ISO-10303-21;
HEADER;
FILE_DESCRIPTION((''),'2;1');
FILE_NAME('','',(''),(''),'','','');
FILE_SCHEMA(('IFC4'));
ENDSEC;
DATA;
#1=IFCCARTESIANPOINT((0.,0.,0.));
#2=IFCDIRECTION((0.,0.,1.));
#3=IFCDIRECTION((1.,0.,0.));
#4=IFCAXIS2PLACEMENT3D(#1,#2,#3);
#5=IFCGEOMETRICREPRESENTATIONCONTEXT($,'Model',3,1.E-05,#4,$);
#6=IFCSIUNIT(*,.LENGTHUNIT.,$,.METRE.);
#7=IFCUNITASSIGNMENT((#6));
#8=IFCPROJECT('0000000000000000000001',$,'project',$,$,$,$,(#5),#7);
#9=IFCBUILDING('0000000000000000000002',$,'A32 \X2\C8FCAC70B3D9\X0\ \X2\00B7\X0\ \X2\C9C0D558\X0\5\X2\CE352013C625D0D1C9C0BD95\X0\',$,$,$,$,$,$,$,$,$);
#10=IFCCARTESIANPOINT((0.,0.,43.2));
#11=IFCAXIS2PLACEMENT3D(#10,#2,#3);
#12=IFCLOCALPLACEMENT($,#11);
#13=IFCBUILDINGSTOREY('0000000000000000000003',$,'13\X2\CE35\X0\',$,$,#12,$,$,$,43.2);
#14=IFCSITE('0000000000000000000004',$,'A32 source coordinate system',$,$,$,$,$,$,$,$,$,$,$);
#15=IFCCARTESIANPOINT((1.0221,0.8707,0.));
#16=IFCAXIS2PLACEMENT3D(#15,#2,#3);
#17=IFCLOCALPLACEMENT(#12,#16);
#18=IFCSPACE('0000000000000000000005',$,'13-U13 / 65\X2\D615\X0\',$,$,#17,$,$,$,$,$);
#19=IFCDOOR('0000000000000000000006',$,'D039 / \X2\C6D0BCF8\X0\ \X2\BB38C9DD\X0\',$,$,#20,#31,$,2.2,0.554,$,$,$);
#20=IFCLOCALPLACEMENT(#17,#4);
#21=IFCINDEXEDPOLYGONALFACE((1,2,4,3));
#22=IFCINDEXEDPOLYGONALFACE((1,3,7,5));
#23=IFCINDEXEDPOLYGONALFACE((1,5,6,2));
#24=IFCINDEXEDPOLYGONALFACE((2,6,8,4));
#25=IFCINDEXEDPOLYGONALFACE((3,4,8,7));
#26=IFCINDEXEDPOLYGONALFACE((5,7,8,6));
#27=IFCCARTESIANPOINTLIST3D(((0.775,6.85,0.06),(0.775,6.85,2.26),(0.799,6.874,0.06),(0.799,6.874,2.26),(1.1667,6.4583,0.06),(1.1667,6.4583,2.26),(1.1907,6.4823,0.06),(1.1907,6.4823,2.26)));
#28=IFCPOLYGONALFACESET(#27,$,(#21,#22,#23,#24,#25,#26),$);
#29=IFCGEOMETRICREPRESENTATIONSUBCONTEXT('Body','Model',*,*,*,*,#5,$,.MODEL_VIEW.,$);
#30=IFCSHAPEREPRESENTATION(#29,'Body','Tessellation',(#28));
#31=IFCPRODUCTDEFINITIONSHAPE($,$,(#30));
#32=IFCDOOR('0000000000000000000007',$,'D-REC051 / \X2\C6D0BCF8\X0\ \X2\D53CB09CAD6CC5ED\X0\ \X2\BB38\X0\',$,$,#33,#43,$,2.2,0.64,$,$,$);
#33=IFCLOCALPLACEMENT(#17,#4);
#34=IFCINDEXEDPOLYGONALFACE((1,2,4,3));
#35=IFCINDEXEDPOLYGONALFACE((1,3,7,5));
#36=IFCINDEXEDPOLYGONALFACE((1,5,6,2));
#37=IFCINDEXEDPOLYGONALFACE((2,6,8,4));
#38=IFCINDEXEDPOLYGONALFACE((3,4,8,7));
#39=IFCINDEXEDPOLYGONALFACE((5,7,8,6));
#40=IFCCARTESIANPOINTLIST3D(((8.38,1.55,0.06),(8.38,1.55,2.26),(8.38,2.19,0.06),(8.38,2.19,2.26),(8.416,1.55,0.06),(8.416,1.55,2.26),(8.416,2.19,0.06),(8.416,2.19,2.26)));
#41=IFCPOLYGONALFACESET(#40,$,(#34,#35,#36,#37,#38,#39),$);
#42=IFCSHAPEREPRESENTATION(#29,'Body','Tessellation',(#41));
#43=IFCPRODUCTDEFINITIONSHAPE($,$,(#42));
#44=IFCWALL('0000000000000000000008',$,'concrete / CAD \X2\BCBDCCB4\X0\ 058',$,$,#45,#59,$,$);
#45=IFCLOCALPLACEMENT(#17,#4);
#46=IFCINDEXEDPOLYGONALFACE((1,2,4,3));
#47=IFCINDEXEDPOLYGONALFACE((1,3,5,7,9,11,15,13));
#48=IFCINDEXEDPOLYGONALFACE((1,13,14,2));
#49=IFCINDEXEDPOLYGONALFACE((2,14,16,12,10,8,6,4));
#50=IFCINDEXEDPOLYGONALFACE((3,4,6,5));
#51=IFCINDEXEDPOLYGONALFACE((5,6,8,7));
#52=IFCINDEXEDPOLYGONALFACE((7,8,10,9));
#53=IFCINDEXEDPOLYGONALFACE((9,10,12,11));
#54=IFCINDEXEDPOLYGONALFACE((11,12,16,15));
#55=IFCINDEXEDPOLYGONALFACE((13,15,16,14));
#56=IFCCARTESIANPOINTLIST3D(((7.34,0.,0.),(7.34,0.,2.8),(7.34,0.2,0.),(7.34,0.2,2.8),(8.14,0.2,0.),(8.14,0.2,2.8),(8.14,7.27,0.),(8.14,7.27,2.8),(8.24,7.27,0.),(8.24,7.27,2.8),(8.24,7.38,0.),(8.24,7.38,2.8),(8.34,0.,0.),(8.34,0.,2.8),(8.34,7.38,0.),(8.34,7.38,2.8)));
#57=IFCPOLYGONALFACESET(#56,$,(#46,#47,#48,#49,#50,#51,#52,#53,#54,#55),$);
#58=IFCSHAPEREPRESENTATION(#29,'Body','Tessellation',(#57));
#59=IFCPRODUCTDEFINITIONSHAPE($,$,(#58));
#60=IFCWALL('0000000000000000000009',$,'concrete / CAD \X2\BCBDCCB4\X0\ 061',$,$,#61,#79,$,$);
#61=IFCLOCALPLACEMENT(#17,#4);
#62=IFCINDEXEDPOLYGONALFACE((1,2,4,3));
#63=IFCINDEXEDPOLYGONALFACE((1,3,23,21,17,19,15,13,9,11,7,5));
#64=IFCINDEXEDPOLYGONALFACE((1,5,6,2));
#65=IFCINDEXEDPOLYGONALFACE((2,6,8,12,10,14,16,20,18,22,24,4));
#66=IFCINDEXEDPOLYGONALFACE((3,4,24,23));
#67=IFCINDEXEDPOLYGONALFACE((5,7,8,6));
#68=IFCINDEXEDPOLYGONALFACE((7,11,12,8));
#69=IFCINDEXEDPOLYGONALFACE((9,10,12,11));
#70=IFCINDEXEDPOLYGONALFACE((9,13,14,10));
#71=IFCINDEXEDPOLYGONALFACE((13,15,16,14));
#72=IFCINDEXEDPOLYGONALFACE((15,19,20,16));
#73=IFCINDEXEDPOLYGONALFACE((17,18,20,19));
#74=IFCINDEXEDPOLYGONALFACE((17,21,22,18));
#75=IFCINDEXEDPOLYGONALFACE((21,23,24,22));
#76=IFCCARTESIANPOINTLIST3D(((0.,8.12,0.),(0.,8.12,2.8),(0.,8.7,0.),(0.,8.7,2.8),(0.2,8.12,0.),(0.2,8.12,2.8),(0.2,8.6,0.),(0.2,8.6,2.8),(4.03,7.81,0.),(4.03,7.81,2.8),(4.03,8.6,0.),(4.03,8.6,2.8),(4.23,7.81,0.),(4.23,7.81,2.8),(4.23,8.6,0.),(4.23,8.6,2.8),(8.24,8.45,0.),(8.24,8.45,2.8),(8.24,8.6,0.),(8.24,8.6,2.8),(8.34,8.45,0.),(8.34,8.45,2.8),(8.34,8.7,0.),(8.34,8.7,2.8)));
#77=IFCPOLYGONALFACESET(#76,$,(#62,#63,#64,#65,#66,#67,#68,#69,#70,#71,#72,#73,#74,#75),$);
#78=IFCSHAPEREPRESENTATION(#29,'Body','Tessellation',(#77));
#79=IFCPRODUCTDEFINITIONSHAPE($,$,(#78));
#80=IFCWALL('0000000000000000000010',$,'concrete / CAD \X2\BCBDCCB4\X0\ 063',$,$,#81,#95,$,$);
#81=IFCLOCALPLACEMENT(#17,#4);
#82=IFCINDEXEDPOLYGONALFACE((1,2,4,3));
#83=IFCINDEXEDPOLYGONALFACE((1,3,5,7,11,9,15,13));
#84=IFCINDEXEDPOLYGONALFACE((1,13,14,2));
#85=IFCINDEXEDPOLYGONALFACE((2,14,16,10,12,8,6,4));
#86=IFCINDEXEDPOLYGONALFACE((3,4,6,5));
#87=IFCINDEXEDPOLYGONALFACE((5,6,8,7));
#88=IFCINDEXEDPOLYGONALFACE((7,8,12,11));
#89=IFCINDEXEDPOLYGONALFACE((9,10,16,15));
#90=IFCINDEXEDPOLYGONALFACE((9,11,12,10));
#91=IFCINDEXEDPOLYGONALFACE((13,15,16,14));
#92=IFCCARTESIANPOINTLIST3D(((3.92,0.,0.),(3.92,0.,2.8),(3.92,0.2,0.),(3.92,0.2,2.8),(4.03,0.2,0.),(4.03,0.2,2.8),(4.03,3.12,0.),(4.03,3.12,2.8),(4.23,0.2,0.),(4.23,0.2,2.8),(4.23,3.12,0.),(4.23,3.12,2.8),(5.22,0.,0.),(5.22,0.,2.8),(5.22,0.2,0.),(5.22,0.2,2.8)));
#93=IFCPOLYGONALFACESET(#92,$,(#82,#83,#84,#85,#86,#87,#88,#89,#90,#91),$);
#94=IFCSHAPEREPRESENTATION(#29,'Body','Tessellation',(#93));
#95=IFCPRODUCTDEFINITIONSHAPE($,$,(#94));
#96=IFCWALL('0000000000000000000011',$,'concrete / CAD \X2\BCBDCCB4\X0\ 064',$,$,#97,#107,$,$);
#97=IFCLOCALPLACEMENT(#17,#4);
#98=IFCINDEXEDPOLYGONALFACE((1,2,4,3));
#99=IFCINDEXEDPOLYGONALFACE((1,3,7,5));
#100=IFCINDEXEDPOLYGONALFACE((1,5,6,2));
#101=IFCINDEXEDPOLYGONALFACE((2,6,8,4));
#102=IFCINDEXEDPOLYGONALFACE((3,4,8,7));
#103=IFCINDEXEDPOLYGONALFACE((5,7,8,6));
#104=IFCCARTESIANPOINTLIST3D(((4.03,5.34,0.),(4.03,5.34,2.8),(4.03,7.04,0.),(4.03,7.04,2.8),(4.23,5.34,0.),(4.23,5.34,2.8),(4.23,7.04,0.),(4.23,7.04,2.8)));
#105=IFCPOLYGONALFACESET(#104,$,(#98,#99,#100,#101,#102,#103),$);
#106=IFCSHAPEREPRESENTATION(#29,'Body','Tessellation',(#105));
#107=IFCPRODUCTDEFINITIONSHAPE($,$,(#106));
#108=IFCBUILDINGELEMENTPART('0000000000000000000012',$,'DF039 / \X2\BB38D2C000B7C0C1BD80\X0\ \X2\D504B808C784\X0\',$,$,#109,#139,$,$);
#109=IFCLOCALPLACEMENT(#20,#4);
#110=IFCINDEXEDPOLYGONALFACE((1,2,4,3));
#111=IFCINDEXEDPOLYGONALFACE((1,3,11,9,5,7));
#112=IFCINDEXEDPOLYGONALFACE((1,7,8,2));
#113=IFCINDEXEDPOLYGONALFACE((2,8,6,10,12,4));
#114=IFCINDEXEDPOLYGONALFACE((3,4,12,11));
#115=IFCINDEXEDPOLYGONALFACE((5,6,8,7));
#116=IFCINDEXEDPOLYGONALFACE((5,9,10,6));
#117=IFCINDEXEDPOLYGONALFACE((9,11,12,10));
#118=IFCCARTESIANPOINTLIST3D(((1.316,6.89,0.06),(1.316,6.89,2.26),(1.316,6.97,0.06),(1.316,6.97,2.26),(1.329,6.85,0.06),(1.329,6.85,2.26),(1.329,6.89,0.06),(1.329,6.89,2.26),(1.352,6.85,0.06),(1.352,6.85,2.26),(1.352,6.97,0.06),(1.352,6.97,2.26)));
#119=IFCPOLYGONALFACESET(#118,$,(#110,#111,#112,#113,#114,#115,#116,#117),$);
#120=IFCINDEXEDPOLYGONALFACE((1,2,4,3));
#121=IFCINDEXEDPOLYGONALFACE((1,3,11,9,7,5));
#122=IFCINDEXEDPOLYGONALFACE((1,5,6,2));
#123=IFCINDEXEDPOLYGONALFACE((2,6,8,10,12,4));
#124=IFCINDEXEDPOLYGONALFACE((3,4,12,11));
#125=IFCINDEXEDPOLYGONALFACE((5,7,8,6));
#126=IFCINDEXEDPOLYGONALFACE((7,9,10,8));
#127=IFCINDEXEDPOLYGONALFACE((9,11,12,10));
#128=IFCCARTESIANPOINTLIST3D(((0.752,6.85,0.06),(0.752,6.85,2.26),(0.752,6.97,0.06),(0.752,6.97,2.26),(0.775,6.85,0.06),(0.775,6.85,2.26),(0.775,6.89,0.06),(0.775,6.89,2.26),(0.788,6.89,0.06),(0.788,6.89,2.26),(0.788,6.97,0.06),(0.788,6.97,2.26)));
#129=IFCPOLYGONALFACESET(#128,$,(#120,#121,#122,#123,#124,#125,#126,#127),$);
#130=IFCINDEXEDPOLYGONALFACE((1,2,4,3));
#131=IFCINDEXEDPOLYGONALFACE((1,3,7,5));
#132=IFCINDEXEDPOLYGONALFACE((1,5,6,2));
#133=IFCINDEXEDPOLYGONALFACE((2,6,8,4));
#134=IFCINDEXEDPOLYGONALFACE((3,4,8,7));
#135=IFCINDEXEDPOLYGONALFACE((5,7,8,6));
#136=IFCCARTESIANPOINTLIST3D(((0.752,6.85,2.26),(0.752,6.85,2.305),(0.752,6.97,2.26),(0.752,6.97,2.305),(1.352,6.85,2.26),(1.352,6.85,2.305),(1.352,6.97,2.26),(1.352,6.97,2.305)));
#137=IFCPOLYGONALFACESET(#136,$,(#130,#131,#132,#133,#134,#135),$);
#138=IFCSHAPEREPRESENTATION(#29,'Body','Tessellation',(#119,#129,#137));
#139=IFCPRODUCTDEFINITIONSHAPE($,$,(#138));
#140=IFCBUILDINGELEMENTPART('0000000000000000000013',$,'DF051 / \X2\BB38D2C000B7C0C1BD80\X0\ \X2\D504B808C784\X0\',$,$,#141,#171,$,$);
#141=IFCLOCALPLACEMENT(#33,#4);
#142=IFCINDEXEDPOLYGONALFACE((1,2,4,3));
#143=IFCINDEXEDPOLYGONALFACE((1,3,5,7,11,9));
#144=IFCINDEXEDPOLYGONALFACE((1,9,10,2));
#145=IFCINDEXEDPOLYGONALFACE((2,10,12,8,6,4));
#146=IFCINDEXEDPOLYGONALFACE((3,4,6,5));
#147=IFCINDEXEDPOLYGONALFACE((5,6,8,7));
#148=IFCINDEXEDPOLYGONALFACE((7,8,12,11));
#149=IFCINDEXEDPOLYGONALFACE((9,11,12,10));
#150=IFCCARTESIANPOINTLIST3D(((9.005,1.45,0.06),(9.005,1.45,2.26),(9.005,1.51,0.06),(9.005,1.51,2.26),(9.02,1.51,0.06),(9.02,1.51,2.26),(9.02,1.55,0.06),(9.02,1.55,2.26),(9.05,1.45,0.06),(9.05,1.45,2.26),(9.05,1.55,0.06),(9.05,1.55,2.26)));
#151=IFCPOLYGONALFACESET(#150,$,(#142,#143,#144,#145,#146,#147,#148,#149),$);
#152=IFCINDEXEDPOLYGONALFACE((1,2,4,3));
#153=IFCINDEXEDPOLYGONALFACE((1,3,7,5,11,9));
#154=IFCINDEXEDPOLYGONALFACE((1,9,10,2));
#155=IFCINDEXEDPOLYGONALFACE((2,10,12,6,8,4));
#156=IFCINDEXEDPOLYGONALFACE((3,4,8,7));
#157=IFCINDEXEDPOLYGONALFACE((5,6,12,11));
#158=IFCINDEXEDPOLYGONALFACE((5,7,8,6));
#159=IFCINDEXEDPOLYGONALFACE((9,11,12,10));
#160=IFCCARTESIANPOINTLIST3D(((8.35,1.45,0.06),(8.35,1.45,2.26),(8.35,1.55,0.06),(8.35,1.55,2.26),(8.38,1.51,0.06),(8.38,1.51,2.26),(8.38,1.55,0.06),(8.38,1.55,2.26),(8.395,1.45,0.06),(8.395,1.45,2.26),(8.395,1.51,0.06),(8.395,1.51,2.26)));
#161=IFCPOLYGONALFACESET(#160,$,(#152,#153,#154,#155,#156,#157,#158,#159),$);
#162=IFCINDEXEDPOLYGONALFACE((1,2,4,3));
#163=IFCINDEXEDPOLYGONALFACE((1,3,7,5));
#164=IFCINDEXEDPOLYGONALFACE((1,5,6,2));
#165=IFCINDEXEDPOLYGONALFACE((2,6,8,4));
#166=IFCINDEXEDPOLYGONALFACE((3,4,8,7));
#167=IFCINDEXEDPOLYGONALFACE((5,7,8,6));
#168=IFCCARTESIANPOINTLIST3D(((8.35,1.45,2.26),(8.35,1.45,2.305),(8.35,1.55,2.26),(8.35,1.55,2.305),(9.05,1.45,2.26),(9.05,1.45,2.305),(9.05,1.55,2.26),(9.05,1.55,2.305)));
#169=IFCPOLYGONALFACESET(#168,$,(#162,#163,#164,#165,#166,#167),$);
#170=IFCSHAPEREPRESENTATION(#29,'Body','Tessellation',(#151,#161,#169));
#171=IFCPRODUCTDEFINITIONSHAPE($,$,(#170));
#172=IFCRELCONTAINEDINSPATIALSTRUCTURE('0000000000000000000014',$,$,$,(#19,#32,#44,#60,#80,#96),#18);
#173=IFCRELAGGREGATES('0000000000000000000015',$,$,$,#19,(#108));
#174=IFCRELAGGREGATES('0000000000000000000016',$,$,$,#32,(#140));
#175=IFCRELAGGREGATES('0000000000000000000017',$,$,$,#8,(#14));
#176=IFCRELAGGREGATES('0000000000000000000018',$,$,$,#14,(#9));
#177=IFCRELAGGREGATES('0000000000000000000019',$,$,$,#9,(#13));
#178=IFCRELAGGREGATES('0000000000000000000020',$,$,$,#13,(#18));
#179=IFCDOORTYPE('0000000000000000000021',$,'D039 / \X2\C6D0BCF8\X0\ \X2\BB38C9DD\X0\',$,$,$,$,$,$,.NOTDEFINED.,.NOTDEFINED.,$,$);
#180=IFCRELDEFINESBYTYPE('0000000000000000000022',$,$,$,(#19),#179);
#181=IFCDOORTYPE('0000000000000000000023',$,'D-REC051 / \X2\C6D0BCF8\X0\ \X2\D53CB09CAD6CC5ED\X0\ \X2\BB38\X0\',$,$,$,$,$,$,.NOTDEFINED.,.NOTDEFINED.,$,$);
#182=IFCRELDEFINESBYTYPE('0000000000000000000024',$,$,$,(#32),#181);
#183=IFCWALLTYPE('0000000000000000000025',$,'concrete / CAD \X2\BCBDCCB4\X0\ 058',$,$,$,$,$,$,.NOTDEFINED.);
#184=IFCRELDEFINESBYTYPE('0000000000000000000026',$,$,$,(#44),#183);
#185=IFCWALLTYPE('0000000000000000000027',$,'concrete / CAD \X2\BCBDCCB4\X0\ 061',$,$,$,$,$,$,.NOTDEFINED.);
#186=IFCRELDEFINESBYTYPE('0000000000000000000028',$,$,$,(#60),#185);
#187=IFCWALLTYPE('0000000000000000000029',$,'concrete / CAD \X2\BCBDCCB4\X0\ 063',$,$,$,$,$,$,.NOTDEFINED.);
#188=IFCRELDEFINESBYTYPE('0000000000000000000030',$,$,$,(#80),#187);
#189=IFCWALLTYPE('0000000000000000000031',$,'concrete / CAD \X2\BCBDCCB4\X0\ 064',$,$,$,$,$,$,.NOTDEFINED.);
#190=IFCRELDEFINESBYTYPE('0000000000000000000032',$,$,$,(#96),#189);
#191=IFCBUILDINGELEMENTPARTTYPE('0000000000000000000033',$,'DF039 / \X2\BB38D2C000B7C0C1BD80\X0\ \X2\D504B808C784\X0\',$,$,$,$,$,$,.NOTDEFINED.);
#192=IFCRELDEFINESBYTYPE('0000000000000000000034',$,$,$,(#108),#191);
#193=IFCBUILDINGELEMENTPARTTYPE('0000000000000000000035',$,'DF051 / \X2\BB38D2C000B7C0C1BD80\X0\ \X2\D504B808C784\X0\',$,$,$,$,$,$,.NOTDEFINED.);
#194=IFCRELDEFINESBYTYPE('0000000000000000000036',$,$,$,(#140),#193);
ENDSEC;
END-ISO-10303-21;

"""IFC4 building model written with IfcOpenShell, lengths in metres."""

from ifc_helpers import new_model, si_unit, frame, origin, origin_with_axes, place, context, subcontext, project, spatial, polyline, outline, extrude, source, transform, mapped, type_object, type_shapes, element, aggregate, save


model = new_model("IFC4")

# Units and contexts
model_context = context("Model", 3, precision=1e-05, world=origin_with_axes())
body_context = subcontext(model_context, "Body", "Model", "MODEL_VIEW")
ifc_project = project(units=[si_unit("LENGTHUNIT", "METRE")], contexts=[model_context])

# Site, building, storey, space
storey_placement = place(None, frame((0.0, 0.0, 43.2), z_axis=(0.0, 0.0, 1.0), x_axis=(1.0, 0.0, 0.0)))
space_placement = place(storey_placement, frame((1.0221, 0.8707, 0.0), z_axis=(0.0, 0.0, 1.0), x_axis=(1.0, 0.0, 0.0)))
site = spatial("IfcSite", under=ifc_project, Name="A32 source coordinate system")
building = spatial("IfcBuilding", under=site, Name="A32 주거동 · 지하5층–옥탑지붕")
storey = spatial("IfcBuildingStorey", under=building, at=storey_placement, Name="13층", Elevation=43.2)
space = spatial("IfcSpace", under=storey, at=space_placement, Name="13-U13 / 65형")

# Doors
door_type_1 = type_object("IfcDoorType", Name="D039 / 원본 문짝", OperationType="NOTDEFINED", PredefinedType="NOTDEFINED")
shared_shape_1 = source(origin(), body_context, "Body", "SweptSolid", [
    extrude(outline(polyline([(1.1907, 6.4823), (1.1667, 6.4583), (0.775, 6.85), (0.799, 6.874), (1.1907, 6.4823)])), frame((0.0, 0.0, 0.06)), (0.0, 0.0, 1.0), 2.2),
])
type_shapes(door_type_1, [shared_shape_1])
door_1_placement = place(space_placement, origin_with_axes())
door_1 = element("IfcDoor", 1, at=door_1_placement, inside=space, type_object=door_type_1, Name="D039 / 원본 문짝", OverallHeight=2.2, OverallWidth=0.554, context=body_context, shape_type="MappedRepresentation", body=[
    mapped(shared_shape_1, transform((0.0, 0.0, 0.0), scale=1.0)),
])
door_type_2 = type_object("IfcDoorType", Name="D-REC051 / 원본 피난구역 문", OperationType="NOTDEFINED", PredefinedType="NOTDEFINED")
shared_shape_2 = source(origin(), body_context, "Body", "SweptSolid", [
    extrude(outline(polyline([(8.416, 2.19), (8.416, 1.55), (8.38, 1.55), (8.38, 2.19), (8.416, 2.19)])), frame((0.0, 0.0, 0.06)), (0.0, 0.0, 1.0), 2.2),
])
type_shapes(door_type_2, [shared_shape_2])
door_2_placement = place(space_placement, origin_with_axes())
door_2 = element("IfcDoor", 2, at=door_2_placement, inside=space, type_object=door_type_2, Name="D-REC051 / 원본 피난구역 문", OverallHeight=2.2, OverallWidth=0.64, context=body_context, shape_type="MappedRepresentation", body=[
    mapped(shared_shape_2, transform((0.0, 0.0, 0.0), scale=1.0)),
])

# Walls
wall_type_1 = type_object("IfcWallType", Name="concrete / CAD 벽체 058", PredefinedType="NOTDEFINED")
shared_shape_3 = source(origin(), body_context, "Body", "SweptSolid", [
    extrude(outline(polyline([(8.34, 0.0), (7.34, 0.0), (7.34, 0.2), (8.14, 0.2), (8.14, 7.27), (8.24, 7.27), (8.24, 7.38), (8.34, 7.38), (8.34, 0.0)])), origin(), (0.0, 0.0, 1.0), 2.8),
])
type_shapes(wall_type_1, [shared_shape_3])
wall_1_placement = place(space_placement, origin_with_axes())
element("IfcWall", 3, at=wall_1_placement, inside=space, type_object=wall_type_1, Name="concrete / CAD 벽체 058", context=body_context, shape_type="MappedRepresentation", body=[
    mapped(shared_shape_3, transform((0.0, 0.0, 0.0), scale=1.0)),
])
wall_type_2 = type_object("IfcWallType", Name="concrete / CAD 벽체 061", PredefinedType="NOTDEFINED")
shared_shape_4 = source(origin(), body_context, "Body", "SweptSolid", [
    extrude(outline(polyline([(0.2, 8.6), (0.2, 8.12), (0.0, 8.12), (0.0, 8.7), (8.34, 8.7), (8.34, 8.45), (8.24, 8.45), (8.24, 8.6), (4.23, 8.6), (4.23, 7.81), (4.03, 7.81), (4.03, 8.6), (0.2, 8.6)])), origin(), (0.0, 0.0, 1.0), 2.8),
])
type_shapes(wall_type_2, [shared_shape_4])
wall_2_placement = place(space_placement, origin_with_axes())
element("IfcWall", 4, at=wall_2_placement, inside=space, type_object=wall_type_2, Name="concrete / CAD 벽체 061", context=body_context, shape_type="MappedRepresentation", body=[
    mapped(shared_shape_4, transform((0.0, 0.0, 0.0), scale=1.0)),
])
wall_type_3 = type_object("IfcWallType", Name="concrete / CAD 벽체 063", PredefinedType="NOTDEFINED")
shared_shape_5 = source(origin(), body_context, "Body", "SweptSolid", [
    extrude(outline(polyline([(5.22, 0.0), (3.92, 0.0), (3.92, 0.2), (4.03, 0.2), (4.03, 3.12), (4.23, 3.12), (4.23, 0.2), (5.22, 0.2), (5.22, 0.0)])), origin(), (0.0, 0.0, 1.0), 2.8),
])
type_shapes(wall_type_3, [shared_shape_5])
wall_3_placement = place(space_placement, origin_with_axes())
element("IfcWall", 5, at=wall_3_placement, inside=space, type_object=wall_type_3, Name="concrete / CAD 벽체 063", context=body_context, shape_type="MappedRepresentation", body=[
    mapped(shared_shape_5, transform((0.0, 0.0, 0.0), scale=1.0)),
])
wall_type_4 = type_object("IfcWallType", Name="concrete / CAD 벽체 064", PredefinedType="NOTDEFINED")
shared_shape_6 = source(origin(), body_context, "Body", "SweptSolid", [
    extrude(outline(polyline([(4.03, 7.04), (4.23, 7.04), (4.23, 5.34), (4.03, 5.34), (4.03, 7.04)])), origin(), (0.0, 0.0, 1.0), 2.8),
])
type_shapes(wall_type_4, [shared_shape_6])
wall_4_placement = place(space_placement, origin_with_axes())
element("IfcWall", 6, at=wall_4_placement, inside=space, type_object=wall_type_4, Name="concrete / CAD 벽체 064", context=body_context, shape_type="MappedRepresentation", body=[
    mapped(shared_shape_6, transform((0.0, 0.0, 0.0), scale=1.0)),
])

# Building element parts
building_element_part_type_1 = type_object("IfcBuildingElementPartType", Name="DF039 / 문틀·상부 프레임", PredefinedType="NOTDEFINED")
shared_shape_7 = source(origin(), body_context, "Body", "SweptSolid", [
    extrude(outline(polyline([(1.352, 6.85), (1.329, 6.85), (1.329, 6.89), (1.316, 6.89), (1.316, 6.97), (1.352, 6.97), (1.352, 6.85)])), frame((0.0, 0.0, 0.06)), (0.0, 0.0, 1.0), 2.2),
    extrude(outline(polyline([(0.788, 6.97), (0.788, 6.89), (0.775, 6.89), (0.775, 6.85), (0.752, 6.85), (0.752, 6.97), (0.788, 6.97)])), frame((0.0, 0.0, 0.06)), (0.0, 0.0, 1.0), 2.2),
    extrude(outline(polyline([(0.752, 6.85), (0.752, 6.97), (1.352, 6.97), (1.352, 6.85), (0.752, 6.85)])), frame((0.0, 0.0, 2.26)), (0.0, 0.0, 1.0), 0.045),
])
type_shapes(building_element_part_type_1, [shared_shape_7])
building_element_part_1_placement = place(door_1_placement, origin_with_axes())
building_element_part_1 = element("IfcBuildingElementPart", 7, at=building_element_part_1_placement, type_object=building_element_part_type_1, Name="DF039 / 문틀·상부 프레임", context=body_context, shape_type="MappedRepresentation", body=[
    mapped(shared_shape_7, transform((0.0, 0.0, 0.0), scale=1.0)),
])
aggregate(door_1, [building_element_part_1])
building_element_part_type_2 = type_object("IfcBuildingElementPartType", Name="DF051 / 문틀·상부 프레임", PredefinedType="NOTDEFINED")
shared_shape_8 = source(origin(), body_context, "Body", "SweptSolid", [
    extrude(outline(polyline([(9.05, 1.45), (9.005, 1.45), (9.005, 1.51), (9.02, 1.51), (9.02, 1.55), (9.05, 1.55), (9.05, 1.45)])), frame((0.0, 0.0, 0.06)), (0.0, 0.0, 1.0), 2.2),
    extrude(outline(polyline([(8.38, 1.55), (8.38, 1.51), (8.395, 1.51), (8.395, 1.45), (8.35, 1.45), (8.35, 1.55), (8.38, 1.55)])), frame((0.0, 0.0, 0.06)), (0.0, 0.0, 1.0), 2.2),
    extrude(outline(polyline([(8.35, 1.45), (8.35, 1.55), (9.05, 1.55), (9.05, 1.45), (8.35, 1.45)])), frame((0.0, 0.0, 2.26)), (0.0, 0.0, 1.0), 0.045),
])
type_shapes(building_element_part_type_2, [shared_shape_8])
building_element_part_2_placement = place(door_2_placement, origin_with_axes())
building_element_part_2 = element("IfcBuildingElementPart", 8, at=building_element_part_2_placement, type_object=building_element_part_type_2, Name="DF051 / 문틀·상부 프레임", context=body_context, shape_type="MappedRepresentation", body=[
    mapped(shared_shape_8, transform((0.0, 0.0, 0.0), scale=1.0)),
])
aggregate(door_2, [building_element_part_2])

save(model, "model.ifc")
